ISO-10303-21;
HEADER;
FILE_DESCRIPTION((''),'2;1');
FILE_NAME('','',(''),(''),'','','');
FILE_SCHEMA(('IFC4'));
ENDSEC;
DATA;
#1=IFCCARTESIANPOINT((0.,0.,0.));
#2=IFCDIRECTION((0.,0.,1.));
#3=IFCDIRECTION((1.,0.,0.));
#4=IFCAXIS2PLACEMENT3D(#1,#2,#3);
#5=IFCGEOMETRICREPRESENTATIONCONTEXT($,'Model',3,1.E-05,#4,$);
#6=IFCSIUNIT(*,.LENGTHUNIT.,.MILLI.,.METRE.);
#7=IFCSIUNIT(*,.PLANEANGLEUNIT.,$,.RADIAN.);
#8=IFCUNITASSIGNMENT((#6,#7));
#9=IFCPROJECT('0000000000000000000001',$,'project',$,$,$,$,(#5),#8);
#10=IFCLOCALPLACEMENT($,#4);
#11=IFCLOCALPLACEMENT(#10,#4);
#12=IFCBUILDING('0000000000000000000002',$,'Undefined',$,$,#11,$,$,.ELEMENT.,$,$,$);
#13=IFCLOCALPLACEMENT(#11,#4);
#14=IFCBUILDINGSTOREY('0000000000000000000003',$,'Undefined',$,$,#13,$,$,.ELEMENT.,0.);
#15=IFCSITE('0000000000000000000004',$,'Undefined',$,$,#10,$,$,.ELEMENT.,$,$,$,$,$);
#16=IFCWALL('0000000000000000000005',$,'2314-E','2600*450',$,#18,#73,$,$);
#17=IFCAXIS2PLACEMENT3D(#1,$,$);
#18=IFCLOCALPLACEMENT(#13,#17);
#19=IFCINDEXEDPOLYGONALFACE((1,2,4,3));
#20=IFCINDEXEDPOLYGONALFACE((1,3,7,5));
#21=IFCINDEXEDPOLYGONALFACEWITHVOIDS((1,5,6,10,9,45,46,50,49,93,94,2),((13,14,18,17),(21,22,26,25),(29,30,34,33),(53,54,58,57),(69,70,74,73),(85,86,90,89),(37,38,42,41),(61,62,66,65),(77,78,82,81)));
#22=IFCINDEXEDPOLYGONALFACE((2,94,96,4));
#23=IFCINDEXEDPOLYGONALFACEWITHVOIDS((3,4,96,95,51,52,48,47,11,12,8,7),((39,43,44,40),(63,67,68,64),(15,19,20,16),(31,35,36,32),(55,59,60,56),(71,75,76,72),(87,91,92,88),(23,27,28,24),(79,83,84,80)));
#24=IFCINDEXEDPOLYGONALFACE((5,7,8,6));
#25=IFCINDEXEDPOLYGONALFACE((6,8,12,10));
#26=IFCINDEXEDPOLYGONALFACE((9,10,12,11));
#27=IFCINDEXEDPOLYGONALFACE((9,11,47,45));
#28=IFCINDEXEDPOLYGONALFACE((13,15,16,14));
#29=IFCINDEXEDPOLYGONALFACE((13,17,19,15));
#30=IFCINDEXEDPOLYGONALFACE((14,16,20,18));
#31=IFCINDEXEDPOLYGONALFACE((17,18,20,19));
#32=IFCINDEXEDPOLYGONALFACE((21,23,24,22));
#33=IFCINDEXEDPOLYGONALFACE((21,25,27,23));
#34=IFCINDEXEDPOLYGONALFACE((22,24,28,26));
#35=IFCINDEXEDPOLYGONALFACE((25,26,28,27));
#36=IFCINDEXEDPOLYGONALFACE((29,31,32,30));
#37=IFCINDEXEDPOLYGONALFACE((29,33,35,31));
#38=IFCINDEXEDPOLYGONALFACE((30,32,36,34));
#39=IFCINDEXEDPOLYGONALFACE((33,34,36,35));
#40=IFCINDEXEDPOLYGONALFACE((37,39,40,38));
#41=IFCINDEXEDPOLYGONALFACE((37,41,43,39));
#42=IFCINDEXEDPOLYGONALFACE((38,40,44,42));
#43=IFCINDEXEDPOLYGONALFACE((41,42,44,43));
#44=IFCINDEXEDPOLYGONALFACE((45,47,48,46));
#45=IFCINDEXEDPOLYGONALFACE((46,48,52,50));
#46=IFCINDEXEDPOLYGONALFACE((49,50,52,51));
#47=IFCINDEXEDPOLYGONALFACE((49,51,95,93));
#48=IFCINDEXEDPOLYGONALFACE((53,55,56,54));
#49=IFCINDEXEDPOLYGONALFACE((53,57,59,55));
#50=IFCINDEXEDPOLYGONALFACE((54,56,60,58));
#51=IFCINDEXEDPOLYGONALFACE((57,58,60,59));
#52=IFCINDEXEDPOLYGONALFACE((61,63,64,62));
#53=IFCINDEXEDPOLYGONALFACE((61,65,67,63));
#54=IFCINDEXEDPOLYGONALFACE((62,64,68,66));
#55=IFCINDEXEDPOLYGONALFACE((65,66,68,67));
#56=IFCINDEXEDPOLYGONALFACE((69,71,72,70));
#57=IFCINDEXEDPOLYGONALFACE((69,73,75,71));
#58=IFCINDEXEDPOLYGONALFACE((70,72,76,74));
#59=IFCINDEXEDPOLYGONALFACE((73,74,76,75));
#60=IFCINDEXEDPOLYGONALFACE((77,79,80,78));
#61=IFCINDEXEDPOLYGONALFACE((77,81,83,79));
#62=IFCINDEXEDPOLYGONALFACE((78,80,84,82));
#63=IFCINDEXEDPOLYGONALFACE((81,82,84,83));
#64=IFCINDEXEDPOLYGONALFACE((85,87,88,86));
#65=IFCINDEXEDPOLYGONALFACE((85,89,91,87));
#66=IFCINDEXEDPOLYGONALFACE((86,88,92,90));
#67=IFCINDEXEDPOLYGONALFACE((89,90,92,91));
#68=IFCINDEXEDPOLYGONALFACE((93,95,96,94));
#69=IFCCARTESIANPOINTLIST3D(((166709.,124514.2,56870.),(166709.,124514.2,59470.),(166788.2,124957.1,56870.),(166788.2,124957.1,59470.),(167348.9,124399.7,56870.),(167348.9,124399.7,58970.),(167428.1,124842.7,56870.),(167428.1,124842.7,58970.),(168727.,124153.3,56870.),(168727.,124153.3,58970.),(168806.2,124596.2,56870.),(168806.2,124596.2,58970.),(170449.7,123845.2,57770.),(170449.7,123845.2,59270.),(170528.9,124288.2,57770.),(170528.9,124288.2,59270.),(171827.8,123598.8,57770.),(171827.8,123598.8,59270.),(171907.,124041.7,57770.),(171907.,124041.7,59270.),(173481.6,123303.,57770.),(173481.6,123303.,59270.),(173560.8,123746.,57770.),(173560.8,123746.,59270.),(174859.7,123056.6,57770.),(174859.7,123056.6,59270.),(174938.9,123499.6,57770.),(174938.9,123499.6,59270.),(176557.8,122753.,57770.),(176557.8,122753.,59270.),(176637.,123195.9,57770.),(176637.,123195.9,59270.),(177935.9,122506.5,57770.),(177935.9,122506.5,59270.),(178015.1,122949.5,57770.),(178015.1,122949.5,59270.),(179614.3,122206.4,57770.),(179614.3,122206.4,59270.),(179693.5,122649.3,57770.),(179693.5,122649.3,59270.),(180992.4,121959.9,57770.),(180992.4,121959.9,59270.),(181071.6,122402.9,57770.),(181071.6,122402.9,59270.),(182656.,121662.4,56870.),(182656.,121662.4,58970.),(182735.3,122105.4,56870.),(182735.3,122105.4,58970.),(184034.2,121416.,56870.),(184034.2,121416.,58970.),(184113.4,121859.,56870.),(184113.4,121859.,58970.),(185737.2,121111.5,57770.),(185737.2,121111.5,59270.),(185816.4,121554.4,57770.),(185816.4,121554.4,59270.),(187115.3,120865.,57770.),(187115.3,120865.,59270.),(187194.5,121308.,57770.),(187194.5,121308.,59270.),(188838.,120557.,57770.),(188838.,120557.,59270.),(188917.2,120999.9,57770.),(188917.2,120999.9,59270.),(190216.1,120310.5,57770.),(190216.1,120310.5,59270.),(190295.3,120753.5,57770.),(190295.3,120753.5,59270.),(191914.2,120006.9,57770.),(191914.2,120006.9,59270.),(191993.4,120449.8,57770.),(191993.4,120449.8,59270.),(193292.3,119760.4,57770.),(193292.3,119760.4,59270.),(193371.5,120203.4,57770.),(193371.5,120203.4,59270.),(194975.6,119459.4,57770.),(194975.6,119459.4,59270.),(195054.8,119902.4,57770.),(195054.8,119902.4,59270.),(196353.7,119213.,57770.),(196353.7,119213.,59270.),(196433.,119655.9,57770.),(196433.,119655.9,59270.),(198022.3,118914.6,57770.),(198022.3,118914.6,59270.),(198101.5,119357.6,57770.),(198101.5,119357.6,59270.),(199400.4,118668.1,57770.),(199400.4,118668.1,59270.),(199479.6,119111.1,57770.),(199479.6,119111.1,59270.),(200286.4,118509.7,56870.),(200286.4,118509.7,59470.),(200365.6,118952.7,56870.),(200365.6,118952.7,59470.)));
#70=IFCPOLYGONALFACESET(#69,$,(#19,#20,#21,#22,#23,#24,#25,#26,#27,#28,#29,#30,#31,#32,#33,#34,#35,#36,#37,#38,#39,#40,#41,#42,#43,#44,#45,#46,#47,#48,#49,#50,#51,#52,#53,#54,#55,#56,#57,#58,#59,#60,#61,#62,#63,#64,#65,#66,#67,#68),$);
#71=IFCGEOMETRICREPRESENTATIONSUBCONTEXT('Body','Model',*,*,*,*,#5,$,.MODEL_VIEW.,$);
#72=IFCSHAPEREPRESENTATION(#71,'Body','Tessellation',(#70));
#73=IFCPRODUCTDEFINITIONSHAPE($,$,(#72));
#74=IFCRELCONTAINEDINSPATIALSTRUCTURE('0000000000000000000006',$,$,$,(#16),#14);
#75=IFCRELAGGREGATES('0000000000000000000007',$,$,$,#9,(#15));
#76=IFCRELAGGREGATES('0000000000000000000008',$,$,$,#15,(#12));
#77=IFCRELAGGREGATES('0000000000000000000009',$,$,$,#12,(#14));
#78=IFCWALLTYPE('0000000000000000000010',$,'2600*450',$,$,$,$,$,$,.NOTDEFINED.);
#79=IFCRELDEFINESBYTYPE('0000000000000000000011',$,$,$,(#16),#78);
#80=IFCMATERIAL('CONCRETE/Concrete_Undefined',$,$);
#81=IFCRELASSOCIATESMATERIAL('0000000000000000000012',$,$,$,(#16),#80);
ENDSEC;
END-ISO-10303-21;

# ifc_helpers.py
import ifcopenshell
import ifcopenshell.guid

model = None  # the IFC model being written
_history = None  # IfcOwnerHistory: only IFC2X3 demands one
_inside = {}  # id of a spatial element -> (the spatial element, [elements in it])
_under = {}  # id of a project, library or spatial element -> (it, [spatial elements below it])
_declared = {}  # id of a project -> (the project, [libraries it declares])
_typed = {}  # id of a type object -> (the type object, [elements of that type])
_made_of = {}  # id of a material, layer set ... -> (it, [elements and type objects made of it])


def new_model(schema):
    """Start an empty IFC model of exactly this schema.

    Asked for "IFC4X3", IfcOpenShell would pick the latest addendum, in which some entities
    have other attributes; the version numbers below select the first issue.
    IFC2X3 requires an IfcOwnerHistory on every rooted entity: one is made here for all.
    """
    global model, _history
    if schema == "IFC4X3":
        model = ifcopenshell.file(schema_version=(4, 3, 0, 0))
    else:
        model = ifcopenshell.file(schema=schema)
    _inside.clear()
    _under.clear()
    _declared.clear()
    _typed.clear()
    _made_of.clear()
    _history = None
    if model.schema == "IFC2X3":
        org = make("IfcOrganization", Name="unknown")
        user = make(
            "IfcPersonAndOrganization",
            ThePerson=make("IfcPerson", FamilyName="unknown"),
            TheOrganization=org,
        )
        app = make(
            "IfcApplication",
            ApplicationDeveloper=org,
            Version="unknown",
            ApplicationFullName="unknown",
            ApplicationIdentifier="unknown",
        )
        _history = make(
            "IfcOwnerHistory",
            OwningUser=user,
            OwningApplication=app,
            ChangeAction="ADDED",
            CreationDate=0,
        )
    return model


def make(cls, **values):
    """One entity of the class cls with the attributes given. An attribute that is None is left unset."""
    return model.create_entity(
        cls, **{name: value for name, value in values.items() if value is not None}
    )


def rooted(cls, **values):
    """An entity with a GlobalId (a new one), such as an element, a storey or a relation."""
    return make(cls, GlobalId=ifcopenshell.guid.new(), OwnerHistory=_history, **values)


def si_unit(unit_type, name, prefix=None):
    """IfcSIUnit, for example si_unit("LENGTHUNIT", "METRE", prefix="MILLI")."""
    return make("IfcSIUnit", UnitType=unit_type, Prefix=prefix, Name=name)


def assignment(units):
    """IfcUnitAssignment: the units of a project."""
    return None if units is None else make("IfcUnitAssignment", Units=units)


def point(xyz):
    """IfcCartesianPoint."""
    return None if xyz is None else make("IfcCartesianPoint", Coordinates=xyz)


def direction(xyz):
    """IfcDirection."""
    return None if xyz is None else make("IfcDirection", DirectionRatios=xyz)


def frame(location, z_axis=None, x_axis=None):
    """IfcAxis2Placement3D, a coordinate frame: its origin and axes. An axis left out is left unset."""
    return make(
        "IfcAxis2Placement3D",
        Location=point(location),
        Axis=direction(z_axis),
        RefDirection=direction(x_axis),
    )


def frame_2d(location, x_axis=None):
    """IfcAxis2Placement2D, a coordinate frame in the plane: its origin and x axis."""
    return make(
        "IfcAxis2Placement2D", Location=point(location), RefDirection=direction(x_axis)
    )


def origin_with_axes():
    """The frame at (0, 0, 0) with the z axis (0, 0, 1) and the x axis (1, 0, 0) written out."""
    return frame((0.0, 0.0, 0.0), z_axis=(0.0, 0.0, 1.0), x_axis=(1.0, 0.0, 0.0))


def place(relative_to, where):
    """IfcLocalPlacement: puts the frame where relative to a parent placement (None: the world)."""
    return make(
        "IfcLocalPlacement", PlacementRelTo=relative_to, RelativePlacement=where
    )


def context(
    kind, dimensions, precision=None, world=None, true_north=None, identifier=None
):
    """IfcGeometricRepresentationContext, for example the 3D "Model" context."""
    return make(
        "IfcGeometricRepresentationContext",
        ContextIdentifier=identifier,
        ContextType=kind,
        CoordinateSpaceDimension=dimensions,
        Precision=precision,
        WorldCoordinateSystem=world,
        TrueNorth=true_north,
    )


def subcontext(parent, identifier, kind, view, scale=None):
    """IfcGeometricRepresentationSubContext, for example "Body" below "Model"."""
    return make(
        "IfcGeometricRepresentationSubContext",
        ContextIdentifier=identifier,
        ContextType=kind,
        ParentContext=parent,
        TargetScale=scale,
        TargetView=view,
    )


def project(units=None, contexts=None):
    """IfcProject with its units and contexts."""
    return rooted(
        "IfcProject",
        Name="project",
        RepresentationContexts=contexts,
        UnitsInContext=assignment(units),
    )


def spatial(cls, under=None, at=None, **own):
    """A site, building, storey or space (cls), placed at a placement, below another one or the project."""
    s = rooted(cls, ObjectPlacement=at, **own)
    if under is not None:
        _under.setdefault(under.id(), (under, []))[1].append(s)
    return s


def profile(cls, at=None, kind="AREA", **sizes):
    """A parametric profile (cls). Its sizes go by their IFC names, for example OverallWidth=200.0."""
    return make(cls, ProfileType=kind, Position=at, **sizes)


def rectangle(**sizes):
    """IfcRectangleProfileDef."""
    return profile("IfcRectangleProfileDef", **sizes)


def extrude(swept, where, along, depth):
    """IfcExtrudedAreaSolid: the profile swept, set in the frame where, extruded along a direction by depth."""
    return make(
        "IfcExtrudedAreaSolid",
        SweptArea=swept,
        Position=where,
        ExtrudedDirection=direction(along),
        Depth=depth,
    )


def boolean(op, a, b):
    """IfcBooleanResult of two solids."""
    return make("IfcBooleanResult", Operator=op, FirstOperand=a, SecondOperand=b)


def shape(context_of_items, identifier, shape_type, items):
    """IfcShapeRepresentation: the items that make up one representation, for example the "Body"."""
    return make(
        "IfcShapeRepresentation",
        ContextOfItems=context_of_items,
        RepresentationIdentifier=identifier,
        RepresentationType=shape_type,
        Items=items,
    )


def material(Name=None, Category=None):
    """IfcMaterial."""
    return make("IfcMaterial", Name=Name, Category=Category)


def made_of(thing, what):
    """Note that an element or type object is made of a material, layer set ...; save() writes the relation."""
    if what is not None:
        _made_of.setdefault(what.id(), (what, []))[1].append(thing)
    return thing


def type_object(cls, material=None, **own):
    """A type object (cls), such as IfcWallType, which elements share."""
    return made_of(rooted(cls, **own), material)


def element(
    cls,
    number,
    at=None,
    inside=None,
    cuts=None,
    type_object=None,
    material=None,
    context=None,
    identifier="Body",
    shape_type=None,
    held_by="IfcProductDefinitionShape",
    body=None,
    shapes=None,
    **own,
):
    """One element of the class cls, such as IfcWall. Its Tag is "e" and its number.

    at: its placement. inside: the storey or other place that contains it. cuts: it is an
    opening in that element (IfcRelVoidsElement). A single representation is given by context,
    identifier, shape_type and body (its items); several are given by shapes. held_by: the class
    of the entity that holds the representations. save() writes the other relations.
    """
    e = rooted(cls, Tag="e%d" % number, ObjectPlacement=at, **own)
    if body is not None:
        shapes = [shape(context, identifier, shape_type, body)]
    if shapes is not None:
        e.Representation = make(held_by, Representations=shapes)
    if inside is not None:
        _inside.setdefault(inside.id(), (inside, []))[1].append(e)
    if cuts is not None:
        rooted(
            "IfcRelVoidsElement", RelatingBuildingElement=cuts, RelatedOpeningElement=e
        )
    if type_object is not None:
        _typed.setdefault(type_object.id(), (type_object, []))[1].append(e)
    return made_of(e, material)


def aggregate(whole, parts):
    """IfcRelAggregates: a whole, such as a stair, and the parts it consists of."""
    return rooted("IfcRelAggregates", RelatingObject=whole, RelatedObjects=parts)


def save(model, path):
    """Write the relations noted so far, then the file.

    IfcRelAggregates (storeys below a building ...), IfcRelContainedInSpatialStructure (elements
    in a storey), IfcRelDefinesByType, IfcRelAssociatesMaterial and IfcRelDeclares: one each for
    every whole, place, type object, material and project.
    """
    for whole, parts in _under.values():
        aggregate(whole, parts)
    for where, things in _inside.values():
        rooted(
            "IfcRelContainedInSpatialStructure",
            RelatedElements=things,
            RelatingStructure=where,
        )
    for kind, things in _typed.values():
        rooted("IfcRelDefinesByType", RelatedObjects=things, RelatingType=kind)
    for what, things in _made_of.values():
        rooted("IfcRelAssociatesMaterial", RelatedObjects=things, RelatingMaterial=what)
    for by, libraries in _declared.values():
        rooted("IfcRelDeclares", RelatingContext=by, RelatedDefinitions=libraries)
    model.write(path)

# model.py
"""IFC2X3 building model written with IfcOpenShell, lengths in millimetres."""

from ifc_helpers import new_model, si_unit, frame, frame_2d, origin_with_axes, place, context, subcontext, project, spatial, rectangle, extrude, boolean, material, type_object, element, save


model = new_model("IFC2X3")

# Units and contexts
model_context = context("Model", 3, precision=1e-05, world=origin_with_axes())
body_context = subcontext(model_context, "Body", "Model", "MODEL_VIEW")
ifc_project = project(units=[si_unit("LENGTHUNIT", "METRE", prefix="MILLI"), si_unit("PLANEANGLEUNIT", "RADIAN")], contexts=[model_context])

# Site, building, storey
site_placement = place(None, origin_with_axes())
site = spatial("IfcSite", under=ifc_project, at=site_placement, Name="Undefined", CompositionType="ELEMENT")
building_placement = place(site_placement, origin_with_axes())
building = spatial("IfcBuilding", under=site, at=building_placement, Name="Undefined", CompositionType="ELEMENT")
storey_placement = place(building_placement, origin_with_axes())
storey = spatial("IfcBuildingStorey", under=building, at=storey_placement, Name="Undefined", CompositionType="ELEMENT", Elevation=0.0)

# Shared definitions
ifc_material_1 = material(Name="CONCRETE/Concrete_Undefined")

# Wall
wall_type_1 = type_object("IfcWallType", Name="2600*450", PredefinedType="NOTDEFINED")
wall_1_placement = place(storey_placement, frame((200326.0, 118731.2, 56870.0), z_axis=(0.0, 0.0, 1.0), x_axis=(-0.984385, 0.176032, 0.0)))
solid_1 = boolean("DIFFERENCE", boolean("DIFFERENCE", boolean("DIFFERENCE", boolean("DIFFERENCE", boolean("DIFFERENCE", boolean("DIFFERENCE", boolean("DIFFERENCE", boolean("DIFFERENCE", extrude(rectangle(XDim=34110.0, YDim=450.0, at=frame_2d((0.0, 17055.0), x_axis=(0.0, -1.0))), frame((0.0, 0.0, 0.0), z_axis=(0.0, 0.0, 1.0), x_axis=(0.0, -1.0, 0.0)), (0.0, 0.0, 1.0), 2600.0), extrude(rectangle(XDim=1400.0, YDim=450.0, at=frame_2d((0.0, 700.0), x_axis=(0.0, -1.0))), frame((33460.0, 0.0, 0.0), z_axis=(0.0, 0.0, 1.0), x_axis=(0.0, 1.0, 0.0)), (0.0, 0.0, 1.0), 2100.0)), extrude(rectangle(XDim=1400.0, YDim=450.0, at=frame_2d((0.0, 700.0), x_axis=(0.0, -1.0))), frame((30310.0, 0.0, 900.0), z_axis=(0.0, 0.0, 1.0), x_axis=(0.0, 1.0, 0.0)), (0.0, 0.0, 1.0), 1500.0)), extrude(rectangle(XDim=1400.0, YDim=450.0, at=frame_2d((0.0, 700.0), x_axis=(0.0, -1.0))), frame((27230.0, 0.0, 900.0), z_axis=(0.0, 0.0, 1.0), x_axis=(0.0, 1.0, 0.0)), (0.0, 0.0, 1.0), 1500.0)), extrude(rectangle(XDim=1400.0, YDim=450.0, at=frame_2d((0.0, 700.0), x_axis=(0.0, -1.0))), frame((24105.0, 0.0, 900.0), z_axis=(0.0, 0.0, 1.0), x_axis=(0.0, 1.0, 0.0)), (0.0, 0.0, 1.0), 1500.0)), extrude(rectangle(XDim=1400.0, YDim=450.0, at=frame_2d((0.0, 700.0), x_axis=(0.0, -1.0))), frame((21000.0, 0.0, 900.0), z_axis=(0.0, 0.0, 1.0), x_axis=(0.0, 1.0, 0.0)), (0.0, 0.0, 1.0), 1500.0)), extrude(rectangle(XDim=1400.0, YDim=450.0, at=frame_2d((0.0, 700.0), x_axis=(0.0, -1.0))), frame((17910.0, 0.0, 0.0), z_axis=(0.0, 0.0, 1.0), x_axis=(0.0, 1.0, 0.0)), (0.0, 0.0, 1.0), 2100.0)), extrude(rectangle(XDim=1400.0, YDim=450.0, at=frame_2d((0.0, 700.0), x_axis=(0.0, -1.0))), frame((14780.0, 0.0, 900.0), z_axis=(0.0, 0.0, 1.0), x_axis=(0.0, 1.0, 0.0)), (0.0, 0.0, 1.0), 1500.0)), extrude(rectangle(XDim=1400.0, YDim=450.0, at=frame_2d((0.0, 700.0), x_axis=(0.0, -1.0))), frame((11630.0, 0.0, 900.0), z_axis=(0.0, 0.0, 1.0), x_axis=(0.0, 1.0, 0.0)), (0.0, 0.0, 1.0), 1500.0))
element("IfcWall", 1, at=wall_1_placement, inside=storey, type_object=wall_type_1, material=ifc_material_1, Name="2314-E", Description="2600*450", context=body_context, shape_type="CSG", body=[
    boolean("DIFFERENCE", boolean("DIFFERENCE", boolean("DIFFERENCE", solid_1, extrude(rectangle(XDim=1400.0, YDim=450.0, at=frame_2d((0.0, 700.0), x_axis=(0.0, -1.0))), frame((8505.0, 0.0, 900.0), z_axis=(0.0, 0.0, 1.0), x_axis=(0.0, 1.0, 0.0)), (0.0, 0.0, 1.0), 1500.0)), extrude(rectangle(XDim=1400.0, YDim=450.0, at=frame_2d((0.0, 700.0), x_axis=(0.0, -1.0))), frame((5395.0, 0.0, 900.0), z_axis=(0.0, 0.0, 1.0), x_axis=(0.0, 1.0, 0.0)), (0.0, 0.0, 1.0), 1500.0)), extrude(rectangle(XDim=1400.0, YDim=450.0, at=frame_2d((0.0, 700.0), x_axis=(0.0, -1.0))), frame((2300.0, 0.0, 900.0), z_axis=(0.0, 0.0, 1.0), x_axis=(0.0, 1.0, 0.0)), (0.0, 0.0, 1.0), 1500.0)),
])

save(model, "model.ifc")
